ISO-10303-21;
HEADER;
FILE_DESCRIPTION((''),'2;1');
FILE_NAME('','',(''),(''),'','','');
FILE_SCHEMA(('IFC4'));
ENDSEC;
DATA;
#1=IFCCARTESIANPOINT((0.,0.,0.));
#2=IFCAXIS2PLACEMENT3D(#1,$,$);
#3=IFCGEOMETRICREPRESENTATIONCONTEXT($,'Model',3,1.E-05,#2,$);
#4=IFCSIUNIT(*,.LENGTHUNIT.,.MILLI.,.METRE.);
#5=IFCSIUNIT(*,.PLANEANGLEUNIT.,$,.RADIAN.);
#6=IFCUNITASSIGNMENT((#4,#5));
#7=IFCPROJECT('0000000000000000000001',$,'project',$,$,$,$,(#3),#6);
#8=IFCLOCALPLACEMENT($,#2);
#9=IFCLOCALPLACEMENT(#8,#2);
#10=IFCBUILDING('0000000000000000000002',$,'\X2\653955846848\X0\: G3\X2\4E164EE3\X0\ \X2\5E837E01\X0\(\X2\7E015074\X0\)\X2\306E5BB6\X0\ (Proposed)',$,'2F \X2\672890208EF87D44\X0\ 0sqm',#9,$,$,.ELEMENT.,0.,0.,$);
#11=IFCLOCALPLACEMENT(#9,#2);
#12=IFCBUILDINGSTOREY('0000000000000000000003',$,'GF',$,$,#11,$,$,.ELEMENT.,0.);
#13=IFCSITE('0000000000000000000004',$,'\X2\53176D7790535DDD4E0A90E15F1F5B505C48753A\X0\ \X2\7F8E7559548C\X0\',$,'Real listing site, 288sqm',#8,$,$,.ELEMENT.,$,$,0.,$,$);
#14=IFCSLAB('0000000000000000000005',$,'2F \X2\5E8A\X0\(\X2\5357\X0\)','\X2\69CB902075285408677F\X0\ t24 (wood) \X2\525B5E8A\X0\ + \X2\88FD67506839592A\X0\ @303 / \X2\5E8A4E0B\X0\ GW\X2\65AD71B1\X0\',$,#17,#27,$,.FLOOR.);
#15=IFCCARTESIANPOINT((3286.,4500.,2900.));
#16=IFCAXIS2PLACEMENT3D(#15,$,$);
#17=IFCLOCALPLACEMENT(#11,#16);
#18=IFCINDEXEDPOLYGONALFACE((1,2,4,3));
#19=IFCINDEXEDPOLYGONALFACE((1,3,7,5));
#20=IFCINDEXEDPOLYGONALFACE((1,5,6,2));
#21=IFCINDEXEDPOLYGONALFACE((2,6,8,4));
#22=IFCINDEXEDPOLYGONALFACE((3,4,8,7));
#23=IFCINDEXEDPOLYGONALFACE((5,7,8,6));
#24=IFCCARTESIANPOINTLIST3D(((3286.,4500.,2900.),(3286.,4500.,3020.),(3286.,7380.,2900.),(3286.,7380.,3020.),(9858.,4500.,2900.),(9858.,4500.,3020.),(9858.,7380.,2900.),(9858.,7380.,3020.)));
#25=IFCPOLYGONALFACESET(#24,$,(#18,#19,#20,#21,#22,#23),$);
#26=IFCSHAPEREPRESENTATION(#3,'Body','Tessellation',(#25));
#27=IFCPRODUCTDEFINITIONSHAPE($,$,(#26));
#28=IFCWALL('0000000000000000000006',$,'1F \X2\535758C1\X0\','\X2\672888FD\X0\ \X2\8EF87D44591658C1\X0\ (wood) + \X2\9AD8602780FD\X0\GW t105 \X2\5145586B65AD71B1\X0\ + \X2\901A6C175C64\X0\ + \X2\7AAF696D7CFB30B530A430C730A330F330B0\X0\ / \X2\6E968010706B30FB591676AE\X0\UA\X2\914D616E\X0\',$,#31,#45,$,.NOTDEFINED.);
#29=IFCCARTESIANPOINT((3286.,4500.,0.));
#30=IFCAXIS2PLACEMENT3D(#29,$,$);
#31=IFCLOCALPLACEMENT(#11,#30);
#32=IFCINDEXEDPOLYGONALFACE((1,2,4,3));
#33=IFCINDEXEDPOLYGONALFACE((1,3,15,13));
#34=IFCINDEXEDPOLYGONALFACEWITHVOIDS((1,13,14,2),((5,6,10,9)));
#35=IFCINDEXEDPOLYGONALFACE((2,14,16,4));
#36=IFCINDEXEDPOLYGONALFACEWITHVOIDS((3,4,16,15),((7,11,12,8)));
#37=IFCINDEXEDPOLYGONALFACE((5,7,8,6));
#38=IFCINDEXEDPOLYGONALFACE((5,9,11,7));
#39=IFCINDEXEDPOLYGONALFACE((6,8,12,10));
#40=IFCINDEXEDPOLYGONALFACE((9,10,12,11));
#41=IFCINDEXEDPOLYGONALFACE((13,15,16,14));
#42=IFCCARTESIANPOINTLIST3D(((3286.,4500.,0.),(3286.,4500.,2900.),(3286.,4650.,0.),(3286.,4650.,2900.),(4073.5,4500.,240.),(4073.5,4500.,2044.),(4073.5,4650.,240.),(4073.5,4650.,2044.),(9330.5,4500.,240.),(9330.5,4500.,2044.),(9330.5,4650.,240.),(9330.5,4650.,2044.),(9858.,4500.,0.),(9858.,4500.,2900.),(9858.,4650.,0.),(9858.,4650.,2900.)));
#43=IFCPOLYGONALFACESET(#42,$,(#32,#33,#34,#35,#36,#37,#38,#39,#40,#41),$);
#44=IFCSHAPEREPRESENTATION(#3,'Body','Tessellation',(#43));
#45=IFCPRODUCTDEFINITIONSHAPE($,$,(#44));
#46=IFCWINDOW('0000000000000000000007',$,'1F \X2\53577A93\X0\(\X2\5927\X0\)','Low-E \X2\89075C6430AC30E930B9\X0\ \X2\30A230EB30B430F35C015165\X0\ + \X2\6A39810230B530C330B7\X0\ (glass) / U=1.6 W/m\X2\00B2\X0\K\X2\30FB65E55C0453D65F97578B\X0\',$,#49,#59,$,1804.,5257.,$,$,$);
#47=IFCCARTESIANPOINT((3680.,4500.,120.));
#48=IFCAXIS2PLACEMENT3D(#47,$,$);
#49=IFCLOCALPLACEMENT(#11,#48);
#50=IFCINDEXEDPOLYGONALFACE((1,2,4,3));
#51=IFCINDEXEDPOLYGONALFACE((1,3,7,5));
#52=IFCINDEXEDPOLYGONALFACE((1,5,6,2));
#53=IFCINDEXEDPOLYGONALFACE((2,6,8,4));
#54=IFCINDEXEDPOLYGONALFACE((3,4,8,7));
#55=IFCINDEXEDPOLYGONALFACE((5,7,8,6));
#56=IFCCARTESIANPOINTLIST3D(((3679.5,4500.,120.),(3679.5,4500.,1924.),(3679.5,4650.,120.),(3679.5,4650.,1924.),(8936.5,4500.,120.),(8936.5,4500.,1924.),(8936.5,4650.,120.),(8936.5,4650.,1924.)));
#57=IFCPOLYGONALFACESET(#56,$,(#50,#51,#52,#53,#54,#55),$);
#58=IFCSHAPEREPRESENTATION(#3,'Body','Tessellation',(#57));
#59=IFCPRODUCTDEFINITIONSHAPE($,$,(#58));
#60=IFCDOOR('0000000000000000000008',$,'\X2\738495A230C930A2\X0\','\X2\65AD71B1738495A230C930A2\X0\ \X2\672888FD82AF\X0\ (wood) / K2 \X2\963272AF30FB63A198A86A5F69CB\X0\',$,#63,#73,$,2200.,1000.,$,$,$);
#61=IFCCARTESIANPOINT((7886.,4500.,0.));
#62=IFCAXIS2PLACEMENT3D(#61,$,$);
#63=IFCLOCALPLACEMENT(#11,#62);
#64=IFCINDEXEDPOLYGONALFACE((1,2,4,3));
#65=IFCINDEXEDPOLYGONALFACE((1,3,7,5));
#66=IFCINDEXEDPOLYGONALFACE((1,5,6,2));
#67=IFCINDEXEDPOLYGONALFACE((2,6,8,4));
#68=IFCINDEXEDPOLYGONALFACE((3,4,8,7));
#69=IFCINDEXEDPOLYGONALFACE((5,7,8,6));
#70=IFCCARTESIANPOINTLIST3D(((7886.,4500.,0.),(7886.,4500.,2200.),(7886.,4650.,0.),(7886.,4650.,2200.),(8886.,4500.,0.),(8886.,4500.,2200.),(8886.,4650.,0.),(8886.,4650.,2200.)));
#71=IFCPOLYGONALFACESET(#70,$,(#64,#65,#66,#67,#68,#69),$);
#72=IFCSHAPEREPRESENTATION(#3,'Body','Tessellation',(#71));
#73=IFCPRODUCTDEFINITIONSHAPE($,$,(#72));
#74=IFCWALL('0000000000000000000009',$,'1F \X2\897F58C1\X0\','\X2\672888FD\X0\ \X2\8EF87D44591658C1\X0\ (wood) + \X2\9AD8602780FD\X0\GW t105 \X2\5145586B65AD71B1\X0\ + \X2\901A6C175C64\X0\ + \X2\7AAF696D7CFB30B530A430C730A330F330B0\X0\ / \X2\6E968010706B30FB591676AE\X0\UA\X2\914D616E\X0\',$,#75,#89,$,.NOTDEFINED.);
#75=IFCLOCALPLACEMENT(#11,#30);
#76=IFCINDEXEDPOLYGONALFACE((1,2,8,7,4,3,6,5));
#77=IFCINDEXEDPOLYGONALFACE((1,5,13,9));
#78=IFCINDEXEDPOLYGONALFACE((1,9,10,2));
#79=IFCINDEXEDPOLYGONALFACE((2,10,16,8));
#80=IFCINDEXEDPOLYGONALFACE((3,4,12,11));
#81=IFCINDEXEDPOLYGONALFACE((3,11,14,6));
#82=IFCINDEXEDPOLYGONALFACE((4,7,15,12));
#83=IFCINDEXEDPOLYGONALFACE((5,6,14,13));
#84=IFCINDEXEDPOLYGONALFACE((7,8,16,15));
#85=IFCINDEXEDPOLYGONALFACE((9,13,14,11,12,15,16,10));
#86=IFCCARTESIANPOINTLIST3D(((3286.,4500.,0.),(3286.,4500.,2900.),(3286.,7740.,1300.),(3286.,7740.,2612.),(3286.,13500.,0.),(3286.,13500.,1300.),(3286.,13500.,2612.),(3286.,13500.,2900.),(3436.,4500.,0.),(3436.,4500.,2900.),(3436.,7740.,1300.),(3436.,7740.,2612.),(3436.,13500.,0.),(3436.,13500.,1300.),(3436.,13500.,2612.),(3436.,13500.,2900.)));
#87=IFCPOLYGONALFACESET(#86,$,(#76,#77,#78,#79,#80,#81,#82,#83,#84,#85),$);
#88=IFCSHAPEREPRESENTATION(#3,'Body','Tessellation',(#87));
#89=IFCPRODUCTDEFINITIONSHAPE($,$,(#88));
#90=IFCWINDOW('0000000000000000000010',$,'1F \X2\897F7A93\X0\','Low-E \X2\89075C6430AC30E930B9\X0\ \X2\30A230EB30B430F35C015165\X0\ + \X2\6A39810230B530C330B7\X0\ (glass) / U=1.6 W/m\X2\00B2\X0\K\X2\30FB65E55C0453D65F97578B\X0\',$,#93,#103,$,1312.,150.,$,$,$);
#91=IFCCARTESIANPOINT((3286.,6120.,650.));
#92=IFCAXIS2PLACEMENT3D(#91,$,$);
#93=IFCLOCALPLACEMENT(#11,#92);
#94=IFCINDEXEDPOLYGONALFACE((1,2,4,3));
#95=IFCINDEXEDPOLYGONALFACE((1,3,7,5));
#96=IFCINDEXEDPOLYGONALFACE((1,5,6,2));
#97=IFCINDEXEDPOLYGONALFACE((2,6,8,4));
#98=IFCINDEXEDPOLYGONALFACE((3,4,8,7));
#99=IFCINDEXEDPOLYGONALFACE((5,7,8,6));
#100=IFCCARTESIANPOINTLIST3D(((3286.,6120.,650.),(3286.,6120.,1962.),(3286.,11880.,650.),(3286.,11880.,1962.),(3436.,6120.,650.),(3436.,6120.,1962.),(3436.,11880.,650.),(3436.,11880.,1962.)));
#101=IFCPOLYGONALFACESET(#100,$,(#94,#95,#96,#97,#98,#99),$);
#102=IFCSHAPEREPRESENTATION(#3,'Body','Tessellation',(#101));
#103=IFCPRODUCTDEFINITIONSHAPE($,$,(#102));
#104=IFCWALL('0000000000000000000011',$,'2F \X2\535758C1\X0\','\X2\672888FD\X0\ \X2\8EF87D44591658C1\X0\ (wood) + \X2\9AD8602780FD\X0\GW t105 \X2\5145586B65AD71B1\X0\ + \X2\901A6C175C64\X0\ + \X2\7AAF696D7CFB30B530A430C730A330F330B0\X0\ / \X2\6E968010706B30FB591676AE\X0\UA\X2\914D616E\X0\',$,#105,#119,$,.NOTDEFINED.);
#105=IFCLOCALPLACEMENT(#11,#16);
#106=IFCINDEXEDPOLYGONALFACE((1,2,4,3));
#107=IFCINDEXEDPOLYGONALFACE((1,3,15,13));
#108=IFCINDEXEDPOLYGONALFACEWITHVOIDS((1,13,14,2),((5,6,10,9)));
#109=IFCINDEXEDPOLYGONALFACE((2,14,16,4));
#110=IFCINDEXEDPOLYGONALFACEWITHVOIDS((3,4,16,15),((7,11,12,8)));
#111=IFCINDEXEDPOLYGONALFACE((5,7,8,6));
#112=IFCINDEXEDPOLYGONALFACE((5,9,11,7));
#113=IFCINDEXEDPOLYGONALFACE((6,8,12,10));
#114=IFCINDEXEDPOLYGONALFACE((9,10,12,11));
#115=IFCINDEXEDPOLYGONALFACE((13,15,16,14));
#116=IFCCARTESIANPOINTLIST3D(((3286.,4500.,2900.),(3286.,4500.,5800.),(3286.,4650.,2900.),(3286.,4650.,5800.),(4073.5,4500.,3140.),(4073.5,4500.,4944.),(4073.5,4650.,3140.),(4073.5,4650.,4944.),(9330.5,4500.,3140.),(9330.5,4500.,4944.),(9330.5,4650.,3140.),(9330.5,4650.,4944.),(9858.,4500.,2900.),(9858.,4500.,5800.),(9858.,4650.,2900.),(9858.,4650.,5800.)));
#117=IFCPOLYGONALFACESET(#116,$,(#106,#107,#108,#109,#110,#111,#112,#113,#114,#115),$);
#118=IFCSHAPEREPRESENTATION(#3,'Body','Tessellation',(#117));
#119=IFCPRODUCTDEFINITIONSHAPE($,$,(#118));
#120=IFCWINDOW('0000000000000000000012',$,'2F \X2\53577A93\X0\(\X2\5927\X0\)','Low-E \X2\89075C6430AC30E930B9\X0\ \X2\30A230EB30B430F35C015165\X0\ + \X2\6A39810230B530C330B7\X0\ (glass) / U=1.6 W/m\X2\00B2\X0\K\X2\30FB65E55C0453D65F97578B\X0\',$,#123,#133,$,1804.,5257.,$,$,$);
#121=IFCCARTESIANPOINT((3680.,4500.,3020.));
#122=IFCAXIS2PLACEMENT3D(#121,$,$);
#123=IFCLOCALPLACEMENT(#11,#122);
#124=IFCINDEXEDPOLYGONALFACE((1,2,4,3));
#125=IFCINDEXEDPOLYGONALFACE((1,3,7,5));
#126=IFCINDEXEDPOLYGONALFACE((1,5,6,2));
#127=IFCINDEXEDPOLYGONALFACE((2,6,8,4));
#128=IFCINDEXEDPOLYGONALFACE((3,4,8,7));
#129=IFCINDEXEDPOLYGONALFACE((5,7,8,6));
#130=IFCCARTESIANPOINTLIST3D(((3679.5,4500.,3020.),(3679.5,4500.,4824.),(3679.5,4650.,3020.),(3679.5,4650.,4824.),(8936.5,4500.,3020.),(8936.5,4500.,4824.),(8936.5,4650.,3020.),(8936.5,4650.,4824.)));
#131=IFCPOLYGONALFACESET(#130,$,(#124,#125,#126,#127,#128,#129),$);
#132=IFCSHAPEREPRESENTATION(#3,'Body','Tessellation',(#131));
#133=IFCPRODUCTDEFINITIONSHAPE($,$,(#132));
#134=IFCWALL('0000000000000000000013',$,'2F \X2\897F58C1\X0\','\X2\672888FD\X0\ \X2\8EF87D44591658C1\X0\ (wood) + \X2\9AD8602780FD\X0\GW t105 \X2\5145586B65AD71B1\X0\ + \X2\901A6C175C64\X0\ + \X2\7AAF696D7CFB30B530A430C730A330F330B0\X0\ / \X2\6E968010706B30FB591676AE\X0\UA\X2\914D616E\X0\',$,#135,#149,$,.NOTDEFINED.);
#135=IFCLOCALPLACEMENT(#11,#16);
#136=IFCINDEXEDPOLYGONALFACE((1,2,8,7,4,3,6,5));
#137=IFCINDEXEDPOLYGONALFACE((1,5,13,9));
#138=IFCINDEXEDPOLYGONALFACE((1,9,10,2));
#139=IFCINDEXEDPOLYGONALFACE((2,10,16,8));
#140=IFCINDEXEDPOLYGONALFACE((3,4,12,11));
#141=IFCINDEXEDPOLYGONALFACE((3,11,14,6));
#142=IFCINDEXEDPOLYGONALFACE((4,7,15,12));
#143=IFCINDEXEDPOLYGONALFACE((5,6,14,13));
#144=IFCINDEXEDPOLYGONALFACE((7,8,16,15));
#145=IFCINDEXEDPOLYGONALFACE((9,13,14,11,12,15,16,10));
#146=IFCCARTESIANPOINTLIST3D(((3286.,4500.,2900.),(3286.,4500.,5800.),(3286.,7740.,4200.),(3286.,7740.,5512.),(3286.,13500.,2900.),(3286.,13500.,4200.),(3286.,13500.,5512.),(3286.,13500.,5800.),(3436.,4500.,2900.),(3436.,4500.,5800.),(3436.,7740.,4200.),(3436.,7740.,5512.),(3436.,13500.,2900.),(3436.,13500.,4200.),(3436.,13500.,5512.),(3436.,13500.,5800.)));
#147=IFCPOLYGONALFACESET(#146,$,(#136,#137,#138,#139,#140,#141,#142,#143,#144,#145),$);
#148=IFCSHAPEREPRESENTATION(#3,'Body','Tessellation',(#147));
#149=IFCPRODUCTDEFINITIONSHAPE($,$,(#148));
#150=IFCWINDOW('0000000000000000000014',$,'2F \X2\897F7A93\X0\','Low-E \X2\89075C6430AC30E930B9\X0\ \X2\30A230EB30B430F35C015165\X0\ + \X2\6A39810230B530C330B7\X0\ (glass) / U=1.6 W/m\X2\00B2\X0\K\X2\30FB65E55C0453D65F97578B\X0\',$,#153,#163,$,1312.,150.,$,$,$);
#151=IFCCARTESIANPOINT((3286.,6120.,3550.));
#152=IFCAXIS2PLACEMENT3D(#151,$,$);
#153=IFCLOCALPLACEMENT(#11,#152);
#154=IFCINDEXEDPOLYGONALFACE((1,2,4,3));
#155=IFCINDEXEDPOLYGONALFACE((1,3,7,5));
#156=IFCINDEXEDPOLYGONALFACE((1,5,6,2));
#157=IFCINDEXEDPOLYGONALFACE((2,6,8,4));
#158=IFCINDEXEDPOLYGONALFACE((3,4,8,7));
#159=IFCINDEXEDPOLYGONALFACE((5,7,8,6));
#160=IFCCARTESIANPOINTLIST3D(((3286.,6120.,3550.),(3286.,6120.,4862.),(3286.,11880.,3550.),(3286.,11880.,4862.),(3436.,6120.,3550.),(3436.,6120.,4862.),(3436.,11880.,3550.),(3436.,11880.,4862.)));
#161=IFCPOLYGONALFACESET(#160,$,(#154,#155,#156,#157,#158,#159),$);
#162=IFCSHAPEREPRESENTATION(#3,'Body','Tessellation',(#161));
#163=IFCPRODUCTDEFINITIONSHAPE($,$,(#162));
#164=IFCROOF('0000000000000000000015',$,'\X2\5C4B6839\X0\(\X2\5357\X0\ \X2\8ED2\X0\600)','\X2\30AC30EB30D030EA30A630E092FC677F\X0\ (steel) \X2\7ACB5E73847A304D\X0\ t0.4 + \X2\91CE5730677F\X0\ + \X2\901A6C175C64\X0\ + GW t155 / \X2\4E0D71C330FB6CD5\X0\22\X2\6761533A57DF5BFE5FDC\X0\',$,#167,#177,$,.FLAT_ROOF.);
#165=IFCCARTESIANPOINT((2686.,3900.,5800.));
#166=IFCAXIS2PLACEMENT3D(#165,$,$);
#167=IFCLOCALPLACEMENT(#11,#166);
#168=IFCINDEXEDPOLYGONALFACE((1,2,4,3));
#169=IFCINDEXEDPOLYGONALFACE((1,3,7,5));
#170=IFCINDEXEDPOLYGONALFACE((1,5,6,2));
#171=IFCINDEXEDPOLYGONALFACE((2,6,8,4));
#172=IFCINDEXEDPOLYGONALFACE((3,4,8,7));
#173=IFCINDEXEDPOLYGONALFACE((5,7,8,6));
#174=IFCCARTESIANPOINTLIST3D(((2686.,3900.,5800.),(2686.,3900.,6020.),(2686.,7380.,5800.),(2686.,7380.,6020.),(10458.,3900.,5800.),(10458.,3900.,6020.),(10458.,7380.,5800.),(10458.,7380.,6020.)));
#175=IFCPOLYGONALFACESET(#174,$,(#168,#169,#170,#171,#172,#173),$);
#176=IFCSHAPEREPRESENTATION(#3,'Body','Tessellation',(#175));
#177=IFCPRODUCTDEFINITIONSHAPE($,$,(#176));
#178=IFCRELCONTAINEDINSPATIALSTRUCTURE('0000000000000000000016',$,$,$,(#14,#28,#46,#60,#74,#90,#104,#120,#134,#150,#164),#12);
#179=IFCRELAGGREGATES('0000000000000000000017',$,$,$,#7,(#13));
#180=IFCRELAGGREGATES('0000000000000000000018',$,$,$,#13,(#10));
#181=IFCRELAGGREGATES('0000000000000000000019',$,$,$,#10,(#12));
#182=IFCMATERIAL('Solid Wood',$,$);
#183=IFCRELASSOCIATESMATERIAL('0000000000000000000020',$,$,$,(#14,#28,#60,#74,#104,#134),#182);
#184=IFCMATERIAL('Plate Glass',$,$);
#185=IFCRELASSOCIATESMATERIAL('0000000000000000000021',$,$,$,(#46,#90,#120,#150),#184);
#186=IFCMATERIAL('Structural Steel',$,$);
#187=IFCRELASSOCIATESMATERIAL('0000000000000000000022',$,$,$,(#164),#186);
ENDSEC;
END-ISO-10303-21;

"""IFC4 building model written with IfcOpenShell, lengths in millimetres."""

from ifc_helpers import new_model, si_unit, frame, frame_2d, origin, place, context, project, spatial, rectangle, extrude, material, element, fill, save


model = new_model("IFC4")

# Units and contexts
model_context = context("Model", 3, precision=1e-05, world=origin())
ifc_project = project(units=[si_unit("LENGTHUNIT", "METRE", prefix="MILLI"), si_unit("PLANEANGLEUNIT", "RADIAN")], contexts=[model_context])

# Site, building, storey
site_placement = place(None, origin())
site = spatial("IfcSite", under=ifc_project, at=site_placement, Name="北海道川上郡弟子屈町 美留和", ObjectType="Real listing site, 288sqm", CompositionType="ELEMENT", RefElevation=0.0)
building_placement = place(site_placement, origin())
building = spatial("IfcBuilding", under=site, at=building_placement, Name="改善案: G3世代 広縁(縁側)の家 (Proposed)", ObjectType="2F 木造軸組 0sqm", CompositionType="ELEMENT", ElevationOfRefHeight=0.0, ElevationOfTerrain=0.0)
storey_placement = place(building_placement, origin())
storey = spatial("IfcBuildingStorey", under=building, at=storey_placement, Name="GF", CompositionType="ELEMENT", Elevation=0.0)

# Slab
ifc_material_1 = material(Name="Solid Wood")
slab_1_placement = place(storey_placement, frame((3286.0, 4500.0, 2900.0)))
element("IfcSlab", 1, at=slab_1_placement, inside=storey, material=ifc_material_1, Name="2F 床(南)", Description="構造用合板 t24 (wood) 剛床 + 製材根太 @303 / 床下 GW断熱", PredefinedType="FLOOR", context=model_context, shape_type="SweptSolid", body=[
    extrude(rectangle(XDim=6572.0, YDim=2880.0, at=frame_2d((3286.0, 1440.0))), frame((3286.0, 4500.0, 2900.0)), (0.0, 0.0, 1.0), 120.0),
])

# Wall, openings, window, door
wall_1_placement = place(storey_placement, frame((3286.0, 4500.0, 0.0)))
wall_1 = element("IfcWall", 2, at=wall_1_placement, inside=storey, material=ifc_material_1, Name="1F 南壁", Description="木製 軸組外壁 (wood) + 高性能GW t105 充填断熱 + 通気層 + 窯業系サイディング / 準耐火・外皮UA配慮", PredefinedType="NOTDEFINED", context=model_context, shape_type="SweptSolid", body=[
    extrude(rectangle(XDim=6572.0, YDim=150.0, at=frame_2d((3286.0, 75.0))), frame((3286.0, 4500.0, 0.0)), (0.0, 0.0, 1.0), 2900.0),
])
opening_1_placement = place(storey_placement, frame((3680.0, 4500.0, 120.0)))
opening_1 = element("IfcOpeningElement", 3, at=opening_1_placement, cuts=wall_1, PredefinedType="NOTDEFINED", context=model_context, shape_type="SweptSolid", body=[
    extrude(rectangle(XDim=5257.0, YDim=150.0, at=frame_2d((2628.0, 75.0))), frame((3680.0, 4500.0, 120.0)), (0.0, 0.0, 1.0), 1804.0),
])
opening_2_placement = place(storey_placement, frame((7886.0, 4500.0, 0.0)))
opening_2 = element("IfcOpeningElement", 4, at=opening_2_placement, cuts=wall_1, PredefinedType="NOTDEFINED", context=model_context, shape_type="SweptSolid", body=[
    extrude(rectangle(XDim=1000.0, YDim=150.0, at=frame_2d((500.0, 75.0))), frame((7886.0, 4500.0, 0.0)), (0.0, 0.0, 1.0), 2200.0),
])
ifc_material_2 = material(Name="Plate Glass")
window_1_placement = place(storey_placement, frame((3680.0, 4500.0, 120.0)))
window_1 = element("IfcWindow", 5, at=window_1_placement, inside=storey, material=ifc_material_2, Name="1F 南窓(大)", Description="Low-E 複層ガラス アルゴン封入 + 樹脂サッシ (glass) / U=1.6 W/m²K・日射取得型", OverallHeight=1804.0, OverallWidth=5257.0, context=model_context, shape_type="SweptSolid", body=[
    extrude(rectangle(XDim=5257.0, YDim=150.0, at=frame_2d((2628.0, 75.0))), frame((3680.0, 4500.0, 120.0)), (0.0, 0.0, 1.0), 1804.0),
])
fill(opening_1, window_1)
door_placement = place(storey_placement, frame((7886.0, 4500.0, 0.0)))
door = element("IfcDoor", 6, at=door_placement, inside=storey, material=ifc_material_1, Name="玄関ドア", Description="断熱玄関ドア 木製芯 (wood) / K2 防犯・採風機構", OverallHeight=2200.0, OverallWidth=1000.0, context=model_context, shape_type="SweptSolid", body=[
    extrude(rectangle(XDim=1000.0, YDim=150.0, at=frame_2d((500.0, 75.0))), frame((7886.0, 4500.0, 0.0)), (0.0, 0.0, 1.0), 2200.0),
])
fill(opening_2, door)

# Walls, openings, windows
wall_2_placement = place(storey_placement, frame((3286.0, 4500.0, 0.0)))
wall_2 = element("IfcWall", 7, at=wall_2_placement, inside=storey, material=ifc_material_1, Name="1F 西壁", Description="木製 軸組外壁 (wood) + 高性能GW t105 充填断熱 + 通気層 + 窯業系サイディング / 準耐火・外皮UA配慮", PredefinedType="NOTDEFINED", context=model_context, shape_type="SweptSolid", body=[
    extrude(rectangle(XDim=150.0, YDim=9000.0, at=frame_2d((75.0, 4500.0))), frame((3286.0, 4500.0, 0.0)), (0.0, 0.0, 1.0), 2900.0),
])
opening_3_placement = place(storey_placement, frame((3286.0, 6120.0, 650.0)))
opening_3 = element("IfcOpeningElement", 8, at=opening_3_placement, cuts=wall_2, PredefinedType="NOTDEFINED", context=model_context, shape_type="SweptSolid", body=[
    extrude(rectangle(XDim=150.0, YDim=5760.0, at=frame_2d((75.0, 2880.0))), frame((3286.0, 6120.0, 650.0)), (0.0, 0.0, 1.0), 1312.0),
])
window_2_placement = place(storey_placement, frame((3286.0, 6120.0, 650.0)))
window_2 = element("IfcWindow", 9, at=window_2_placement, inside=storey, material=ifc_material_2, Name="1F 西窓", Description="Low-E 複層ガラス アルゴン封入 + 樹脂サッシ (glass) / U=1.6 W/m²K・日射取得型", OverallHeight=1312.0, OverallWidth=150.0, context=model_context, shape_type="SweptSolid", body=[
    extrude(rectangle(XDim=150.0, YDim=5760.0, at=frame_2d((75.0, 2880.0))), frame((3286.0, 6120.0, 650.0)), (0.0, 0.0, 1.0), 1312.0),
])
fill(opening_3, window_2)
wall_3_placement = place(storey_placement, frame((3286.0, 4500.0, 2900.0)))
wall_3 = element("IfcWall", 10, at=wall_3_placement, inside=storey, material=ifc_material_1, Name="2F 南壁", Description="木製 軸組外壁 (wood) + 高性能GW t105 充填断熱 + 通気層 + 窯業系サイディング / 準耐火・外皮UA配慮", PredefinedType="NOTDEFINED", context=model_context, shape_type="SweptSolid", body=[
    extrude(rectangle(XDim=6572.0, YDim=150.0, at=frame_2d((3286.0, 75.0))), frame((3286.0, 4500.0, 2900.0)), (0.0, 0.0, 1.0), 2900.0),
])
opening_4_placement = place(storey_placement, frame((3680.0, 4500.0, 3020.0)))
opening_4 = element("IfcOpeningElement", 11, at=opening_4_placement, cuts=wall_3, PredefinedType="NOTDEFINED", context=model_context, shape_type="SweptSolid", body=[
    extrude(rectangle(XDim=5257.0, YDim=150.0, at=frame_2d((2628.0, 75.0))), frame((3680.0, 4500.0, 3020.0)), (0.0, 0.0, 1.0), 1804.0),
])
window_3_placement = place(storey_placement, frame((3680.0, 4500.0, 3020.0)))
window_3 = element("IfcWindow", 12, at=window_3_placement, inside=storey, material=ifc_material_2, Name="2F 南窓(大)", Description="Low-E 複層ガラス アルゴン封入 + 樹脂サッシ (glass) / U=1.6 W/m²K・日射取得型", OverallHeight=1804.0, OverallWidth=5257.0, context=model_context, shape_type="SweptSolid", body=[
    extrude(rectangle(XDim=5257.0, YDim=150.0, at=frame_2d((2628.0, 75.0))), frame((3680.0, 4500.0, 3020.0)), (0.0, 0.0, 1.0), 1804.0),
])
fill(opening_4, window_3)
wall_4_placement = place(storey_placement, frame((3286.0, 4500.0, 2900.0)))
wall_4 = element("IfcWall", 13, at=wall_4_placement, inside=storey, material=ifc_material_1, Name="2F 西壁", Description="木製 軸組外壁 (wood) + 高性能GW t105 充填断熱 + 通気層 + 窯業系サイディング / 準耐火・外皮UA配慮", PredefinedType="NOTDEFINED", context=model_context, shape_type="SweptSolid", body=[
    extrude(rectangle(XDim=150.0, YDim=9000.0, at=frame_2d((75.0, 4500.0))), frame((3286.0, 4500.0, 2900.0)), (0.0, 0.0, 1.0), 2900.0),
])
opening_5_placement = place(storey_placement, frame((3286.0, 6120.0, 3550.0)))
opening_5 = element("IfcOpeningElement", 14, at=opening_5_placement, cuts=wall_4, PredefinedType="NOTDEFINED", context=model_context, shape_type="SweptSolid", body=[
    extrude(rectangle(XDim=150.0, YDim=5760.0, at=frame_2d((75.0, 2880.0))), frame((3286.0, 6120.0, 3550.0)), (0.0, 0.0, 1.0), 1312.0),
])
window_4_placement = place(storey_placement, frame((3286.0, 6120.0, 3550.0)))
window_4 = element("IfcWindow", 15, at=window_4_placement, inside=storey, material=ifc_material_2, Name="2F 西窓", Description="Low-E 複層ガラス アルゴン封入 + 樹脂サッシ (glass) / U=1.6 W/m²K・日射取得型", OverallHeight=1312.0, OverallWidth=150.0, context=model_context, shape_type="SweptSolid", body=[
    extrude(rectangle(XDim=150.0, YDim=5760.0, at=frame_2d((75.0, 2880.0))), frame((3286.0, 6120.0, 3550.0)), (0.0, 0.0, 1.0), 1312.0),
])
fill(opening_5, window_4)

# Roof
ifc_material_3 = material(Name="Structural Steel")
roof_1_placement = place(storey_placement, frame((2686.0, 3900.0, 5800.0)))
element("IfcRoof", 16, at=roof_1_placement, inside=storey, material=ifc_material_3, Name="屋根(南 軒600)", Description="ガルバリウム鋼板 (steel) 立平葺き t0.4 + 野地板 + 通気層 + GW t155 / 不燃・法22条区域対応", PredefinedType="FLAT_ROOF", context=model_context, shape_type="SweptSolid", body=[
    extrude(rectangle(XDim=7772.0, YDim=3480.0, at=frame_2d((3886.0, 1740.0))), frame((2686.0, 3900.0, 5800.0)), (0.0, 0.0, 1.0), 220.0),
])

save(model, "model.ifc")
